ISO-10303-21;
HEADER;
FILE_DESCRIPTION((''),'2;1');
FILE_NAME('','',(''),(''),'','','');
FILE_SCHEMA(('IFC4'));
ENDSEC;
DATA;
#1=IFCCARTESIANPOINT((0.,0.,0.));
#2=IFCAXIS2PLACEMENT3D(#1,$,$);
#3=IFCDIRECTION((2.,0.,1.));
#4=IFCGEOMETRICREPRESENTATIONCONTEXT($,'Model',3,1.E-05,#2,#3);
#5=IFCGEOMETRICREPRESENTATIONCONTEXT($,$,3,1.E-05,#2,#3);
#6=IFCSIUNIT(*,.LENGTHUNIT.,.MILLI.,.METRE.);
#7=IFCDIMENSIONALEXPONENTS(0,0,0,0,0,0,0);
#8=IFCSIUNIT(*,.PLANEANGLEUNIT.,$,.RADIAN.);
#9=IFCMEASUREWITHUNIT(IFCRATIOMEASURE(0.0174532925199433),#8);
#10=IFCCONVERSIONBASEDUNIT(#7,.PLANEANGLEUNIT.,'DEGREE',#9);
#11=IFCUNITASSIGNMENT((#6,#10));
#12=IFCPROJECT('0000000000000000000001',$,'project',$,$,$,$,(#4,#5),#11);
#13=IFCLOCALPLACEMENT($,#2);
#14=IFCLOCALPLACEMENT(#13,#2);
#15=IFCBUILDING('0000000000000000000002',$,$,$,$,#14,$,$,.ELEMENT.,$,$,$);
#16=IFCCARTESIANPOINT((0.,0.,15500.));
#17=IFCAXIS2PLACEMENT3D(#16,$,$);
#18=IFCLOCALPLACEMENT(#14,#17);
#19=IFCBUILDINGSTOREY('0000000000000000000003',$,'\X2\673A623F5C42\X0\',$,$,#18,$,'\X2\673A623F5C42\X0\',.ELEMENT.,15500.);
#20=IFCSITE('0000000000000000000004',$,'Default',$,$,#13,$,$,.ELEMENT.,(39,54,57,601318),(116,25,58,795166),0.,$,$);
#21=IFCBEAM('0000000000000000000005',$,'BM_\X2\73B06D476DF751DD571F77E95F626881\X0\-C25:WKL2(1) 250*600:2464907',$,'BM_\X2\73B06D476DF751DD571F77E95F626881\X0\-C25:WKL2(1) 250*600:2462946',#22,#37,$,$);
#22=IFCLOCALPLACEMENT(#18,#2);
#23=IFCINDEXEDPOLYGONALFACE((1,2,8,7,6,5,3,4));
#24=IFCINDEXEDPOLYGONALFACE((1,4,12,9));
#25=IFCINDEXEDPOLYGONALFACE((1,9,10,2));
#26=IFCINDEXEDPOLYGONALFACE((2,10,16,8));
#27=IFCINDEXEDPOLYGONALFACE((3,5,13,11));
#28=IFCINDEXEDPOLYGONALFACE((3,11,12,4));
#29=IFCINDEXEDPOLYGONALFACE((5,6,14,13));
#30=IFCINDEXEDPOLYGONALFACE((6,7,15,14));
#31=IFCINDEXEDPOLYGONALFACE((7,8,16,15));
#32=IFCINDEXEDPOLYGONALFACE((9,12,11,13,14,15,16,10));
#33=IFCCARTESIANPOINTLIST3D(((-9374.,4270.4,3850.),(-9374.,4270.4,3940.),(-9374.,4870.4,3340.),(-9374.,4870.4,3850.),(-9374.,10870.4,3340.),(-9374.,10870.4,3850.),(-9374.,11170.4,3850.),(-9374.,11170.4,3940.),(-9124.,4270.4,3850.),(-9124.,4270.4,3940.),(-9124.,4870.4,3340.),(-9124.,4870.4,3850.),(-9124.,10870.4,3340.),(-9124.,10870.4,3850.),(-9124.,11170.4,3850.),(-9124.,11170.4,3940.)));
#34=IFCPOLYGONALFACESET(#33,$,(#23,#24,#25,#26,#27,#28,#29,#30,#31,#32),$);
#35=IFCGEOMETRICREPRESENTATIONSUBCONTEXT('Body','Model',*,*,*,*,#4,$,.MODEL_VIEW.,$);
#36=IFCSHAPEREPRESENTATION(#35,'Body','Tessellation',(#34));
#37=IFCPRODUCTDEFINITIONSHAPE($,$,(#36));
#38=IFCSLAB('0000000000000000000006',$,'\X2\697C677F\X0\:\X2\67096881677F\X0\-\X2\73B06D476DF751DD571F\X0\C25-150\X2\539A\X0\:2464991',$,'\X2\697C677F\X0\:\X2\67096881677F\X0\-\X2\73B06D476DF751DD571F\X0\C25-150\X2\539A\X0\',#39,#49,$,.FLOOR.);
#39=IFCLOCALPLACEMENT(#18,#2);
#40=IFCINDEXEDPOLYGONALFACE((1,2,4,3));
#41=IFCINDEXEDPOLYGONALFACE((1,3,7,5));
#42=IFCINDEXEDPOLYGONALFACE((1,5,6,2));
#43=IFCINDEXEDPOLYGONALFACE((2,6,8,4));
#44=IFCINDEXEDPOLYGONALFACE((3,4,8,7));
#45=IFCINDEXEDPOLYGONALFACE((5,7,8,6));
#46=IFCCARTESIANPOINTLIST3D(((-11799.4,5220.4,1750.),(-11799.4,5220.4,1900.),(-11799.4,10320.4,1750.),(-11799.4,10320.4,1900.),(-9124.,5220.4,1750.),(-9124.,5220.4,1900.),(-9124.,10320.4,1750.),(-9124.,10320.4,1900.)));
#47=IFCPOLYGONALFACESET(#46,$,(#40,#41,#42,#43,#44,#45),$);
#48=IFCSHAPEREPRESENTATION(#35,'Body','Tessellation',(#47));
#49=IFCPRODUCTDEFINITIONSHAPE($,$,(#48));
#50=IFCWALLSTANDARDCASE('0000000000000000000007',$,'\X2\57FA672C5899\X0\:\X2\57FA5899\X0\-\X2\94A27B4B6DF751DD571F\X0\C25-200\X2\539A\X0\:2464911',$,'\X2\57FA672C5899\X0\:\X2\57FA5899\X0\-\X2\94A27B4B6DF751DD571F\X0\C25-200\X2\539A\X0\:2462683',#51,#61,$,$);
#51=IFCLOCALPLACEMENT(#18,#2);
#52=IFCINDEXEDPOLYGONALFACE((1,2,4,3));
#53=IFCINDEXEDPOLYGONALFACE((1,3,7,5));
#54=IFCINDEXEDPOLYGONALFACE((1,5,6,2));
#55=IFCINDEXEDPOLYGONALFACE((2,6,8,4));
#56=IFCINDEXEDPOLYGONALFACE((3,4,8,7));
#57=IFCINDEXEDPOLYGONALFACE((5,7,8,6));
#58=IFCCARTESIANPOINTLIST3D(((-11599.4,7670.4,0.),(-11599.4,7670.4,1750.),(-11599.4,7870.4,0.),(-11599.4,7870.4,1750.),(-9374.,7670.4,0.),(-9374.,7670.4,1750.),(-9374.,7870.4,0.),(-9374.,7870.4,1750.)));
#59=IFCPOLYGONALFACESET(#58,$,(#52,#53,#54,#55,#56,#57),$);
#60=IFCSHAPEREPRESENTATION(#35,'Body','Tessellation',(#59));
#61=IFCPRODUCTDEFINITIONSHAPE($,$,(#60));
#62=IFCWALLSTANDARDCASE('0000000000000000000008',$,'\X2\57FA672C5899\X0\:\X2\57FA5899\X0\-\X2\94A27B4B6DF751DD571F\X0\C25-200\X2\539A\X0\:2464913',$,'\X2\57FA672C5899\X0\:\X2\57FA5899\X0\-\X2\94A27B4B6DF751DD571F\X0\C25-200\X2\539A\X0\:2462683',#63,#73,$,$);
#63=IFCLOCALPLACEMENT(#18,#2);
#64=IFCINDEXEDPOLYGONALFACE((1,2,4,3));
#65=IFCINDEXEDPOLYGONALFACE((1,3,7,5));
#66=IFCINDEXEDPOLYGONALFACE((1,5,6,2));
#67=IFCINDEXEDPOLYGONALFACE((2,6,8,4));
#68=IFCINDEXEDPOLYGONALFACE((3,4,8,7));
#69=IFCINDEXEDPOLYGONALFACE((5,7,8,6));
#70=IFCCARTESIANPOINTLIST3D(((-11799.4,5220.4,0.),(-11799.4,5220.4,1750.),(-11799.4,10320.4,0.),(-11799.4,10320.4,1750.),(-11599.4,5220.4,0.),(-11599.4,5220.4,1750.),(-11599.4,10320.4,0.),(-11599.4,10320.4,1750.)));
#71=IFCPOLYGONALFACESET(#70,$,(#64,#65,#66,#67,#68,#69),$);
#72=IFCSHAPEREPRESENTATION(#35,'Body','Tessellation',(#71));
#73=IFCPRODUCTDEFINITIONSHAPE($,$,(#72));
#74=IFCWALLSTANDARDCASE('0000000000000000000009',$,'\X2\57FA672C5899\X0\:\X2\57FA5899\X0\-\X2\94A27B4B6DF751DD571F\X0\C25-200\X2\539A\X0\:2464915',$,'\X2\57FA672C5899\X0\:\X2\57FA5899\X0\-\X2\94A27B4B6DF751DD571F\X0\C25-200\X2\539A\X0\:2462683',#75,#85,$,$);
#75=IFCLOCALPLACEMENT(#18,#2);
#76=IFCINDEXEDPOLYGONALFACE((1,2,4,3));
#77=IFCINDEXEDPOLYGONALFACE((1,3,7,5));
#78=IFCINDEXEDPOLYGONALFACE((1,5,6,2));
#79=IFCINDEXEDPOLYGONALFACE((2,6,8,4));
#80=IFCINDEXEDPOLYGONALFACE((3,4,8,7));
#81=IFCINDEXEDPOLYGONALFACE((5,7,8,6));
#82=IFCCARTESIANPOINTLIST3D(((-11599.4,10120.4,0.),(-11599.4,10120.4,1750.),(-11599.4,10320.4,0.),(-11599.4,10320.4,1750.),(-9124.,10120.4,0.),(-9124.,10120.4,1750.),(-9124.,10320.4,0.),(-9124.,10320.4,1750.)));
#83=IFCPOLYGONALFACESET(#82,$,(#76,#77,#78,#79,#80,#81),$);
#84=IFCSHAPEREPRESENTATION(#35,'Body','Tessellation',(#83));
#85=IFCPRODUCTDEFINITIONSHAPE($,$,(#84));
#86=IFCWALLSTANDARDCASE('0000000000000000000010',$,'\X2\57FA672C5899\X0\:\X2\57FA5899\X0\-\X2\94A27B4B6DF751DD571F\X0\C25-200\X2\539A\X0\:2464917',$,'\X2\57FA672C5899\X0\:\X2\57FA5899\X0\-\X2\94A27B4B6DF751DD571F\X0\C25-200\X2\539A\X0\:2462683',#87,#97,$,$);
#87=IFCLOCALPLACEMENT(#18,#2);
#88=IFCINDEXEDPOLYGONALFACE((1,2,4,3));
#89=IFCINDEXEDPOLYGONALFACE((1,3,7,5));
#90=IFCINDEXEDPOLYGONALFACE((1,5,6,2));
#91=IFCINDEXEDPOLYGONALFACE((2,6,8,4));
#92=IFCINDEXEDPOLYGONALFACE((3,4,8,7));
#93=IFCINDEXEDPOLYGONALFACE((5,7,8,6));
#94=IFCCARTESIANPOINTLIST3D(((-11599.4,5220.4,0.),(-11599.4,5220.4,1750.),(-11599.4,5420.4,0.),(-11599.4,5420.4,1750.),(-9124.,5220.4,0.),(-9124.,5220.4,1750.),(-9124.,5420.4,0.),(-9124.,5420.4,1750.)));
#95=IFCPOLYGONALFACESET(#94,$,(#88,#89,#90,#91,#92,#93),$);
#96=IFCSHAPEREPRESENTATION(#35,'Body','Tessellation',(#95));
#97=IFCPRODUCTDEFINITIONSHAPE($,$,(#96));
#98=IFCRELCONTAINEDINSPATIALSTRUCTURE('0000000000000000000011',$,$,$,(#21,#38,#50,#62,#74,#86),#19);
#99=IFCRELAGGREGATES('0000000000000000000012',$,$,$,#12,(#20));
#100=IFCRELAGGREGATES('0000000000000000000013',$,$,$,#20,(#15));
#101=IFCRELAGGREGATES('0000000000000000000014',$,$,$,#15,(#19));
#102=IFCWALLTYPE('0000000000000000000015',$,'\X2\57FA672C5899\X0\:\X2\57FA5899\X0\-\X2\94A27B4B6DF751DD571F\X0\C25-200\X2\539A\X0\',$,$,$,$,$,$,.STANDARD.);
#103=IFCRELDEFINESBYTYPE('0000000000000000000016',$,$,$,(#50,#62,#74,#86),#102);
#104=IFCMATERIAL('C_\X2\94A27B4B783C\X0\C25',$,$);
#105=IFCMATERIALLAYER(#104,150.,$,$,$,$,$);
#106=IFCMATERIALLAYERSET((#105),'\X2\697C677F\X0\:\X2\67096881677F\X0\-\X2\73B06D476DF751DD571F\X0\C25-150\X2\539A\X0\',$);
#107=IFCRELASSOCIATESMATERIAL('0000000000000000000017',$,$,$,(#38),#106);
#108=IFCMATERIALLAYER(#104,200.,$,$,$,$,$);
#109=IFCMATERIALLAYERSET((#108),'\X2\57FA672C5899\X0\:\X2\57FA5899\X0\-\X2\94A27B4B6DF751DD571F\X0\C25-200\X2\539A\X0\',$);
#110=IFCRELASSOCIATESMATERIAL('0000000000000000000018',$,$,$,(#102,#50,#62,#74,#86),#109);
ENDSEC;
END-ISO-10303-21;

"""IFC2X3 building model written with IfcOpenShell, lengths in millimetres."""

from ifc_helpers import new_model, entity, si_unit, converted_unit, direction, frame, frame_2d, origin, place, context, subcontext, project, spatial, polyline, rectangle, extrude, clip, bounded_halfspace, material, layer, layer_set, layer_usage, type_object, element, save


model = new_model("IFC2X3")

# Units and contexts
model_context = context("Model", 3, precision=1e-05, world=origin(), true_north=direction((2.0, 0.0, 1.0)))
context_of_model = context(None, 3, precision=1e-05, world=origin(), true_north=direction((2.0, 0.0, 1.0)))
body_context = subcontext(model_context, "Body", "Model", "MODEL_VIEW")
ifc_project = project(units=[si_unit("LENGTHUNIT", "METRE", prefix="MILLI"), converted_unit("PLANEANGLEUNIT", "DEGREE", entity("IfcRatioMeasure", 0.0174532925199433), si_unit("PLANEANGLEUNIT", "RADIAN"), dimensions=[0, 0, 0, 0, 0, 0, 0])], contexts=[model_context, context_of_model])

# Site, building, storey
site_placement = place(None, origin())
site = spatial("IfcSite", under=ifc_project, at=site_placement, Name="Default", CompositionType="ELEMENT", RefLatitude=(39, 54, 57, 601318), RefLongitude=(116, 25, 58, 795166), RefElevation=0.0)
building_placement = place(site_placement, origin())
building = spatial("IfcBuilding", under=site, at=building_placement, CompositionType="ELEMENT")
storey_placement = place(building_placement, frame((0.0, 0.0, 15500.0)))
storey = spatial("IfcBuildingStorey", under=building, at=storey_placement, Name="机房层", LongName="机房层", CompositionType="ELEMENT", Elevation=15500.0)

# Shared definitions
ifc_material = material(Name="C_钢筋砼C25")

# Beam
beam_1_placement = place(storey_placement, frame((-9249.0, 11170.4, 3940.0), z_axis=(0.0, 0.0, 1.0), x_axis=(0.0, -1.0, 0.0)))
element("IfcBeam", 1, at=beam_1_placement, inside=storey, Name="BM_现浇混凝土矩形梁-C25:WKL2(1) 250*600:2464907", ObjectType="BM_现浇混凝土矩形梁-C25:WKL2(1) 250*600:2462946", context=body_context, shape_type="Clipping", body=[
    clip(clip(extrude(rectangle(XDim=600.0, YDim=250.0, at=frame_2d((0.0, 0.0), x_axis=(0.0, 1.0))), frame((0.0, 0.0, -300.0), z_axis=(1.0, 0.0, 0.0), x_axis=(0.0, 1.0, 0.0)), (0.0, 0.0, 1.0), 6900.0), bounded_halfspace(frame((6300.0, 125.0, -90.0), z_axis=(1.0, 0.0, 0.0), x_axis=(0.0, 0.0, -1.0)), False, frame((0.0, 0.0, -300.0), z_axis=(1.0, 0.0, 0.0), x_axis=(0.0, 1.0, 0.0)), polyline([(125.0, -300.0), (125.0, 159.4), (125.0, 210.0), (-125.0, 210.0), (-125.0, 189.2), (-125.0, -300.0), (125.0, -300.0)]))), bounded_halfspace(frame((300.0, -300.0, -90.0), z_axis=(-1.0, 0.0, 0.0), x_axis=(0.0, 0.0, 1.0)), False, frame((0.0, 0.0, -300.0), z_axis=(1.0, 0.0, 0.0), x_axis=(0.0, 1.0, 0.0)), polyline([(-125.0, 210.0), (125.0, 210.0), (125.0, -300.0), (-125.0, -300.0), (-125.0, 210.0)]))),
])

# Slab
ifc_layer_1 = layer(ifc_material, 150.0)
ifc_layer_set_1 = layer_set([ifc_layer_1], Name="楼板:有梁板-现浇混凝土C25-150厚")
ifc_layer_usage_1 = layer_usage(ifc_layer_set_1, "AXIS3", "POSITIVE", 0.0)
slab_1_placement = place(storey_placement, origin())
element("IfcSlab", 2, at=slab_1_placement, inside=storey, material=ifc_layer_usage_1, Name="楼板:有梁板-现浇混凝土C25-150厚:2464991", ObjectType="楼板:有梁板-现浇混凝土C25-150厚", PredefinedType="FLOOR", context=body_context, shape_type="SweptSolid", body=[
    extrude(rectangle(XDim=5100.0, YDim=2675.4, at=frame_2d((0.0, 0.0), x_axis=(1.0, 0.0))), frame((-10461.7, 7770.4, 1900.0), z_axis=(0.0, 0.0, -1.0), x_axis=(0.0, 1.0, 0.0)), (0.0, 0.0, 1.0), 150.0),
])

# Walls
ifc_layer_2 = layer(ifc_material, 200.0)
ifc_layer_set_2 = layer_set([ifc_layer_2], Name="基本墙:基墙-钢筋混凝土C25-200厚")
ifc_layer_usage_2 = layer_usage(ifc_layer_set_2, "AXIS2", "NEGATIVE", 100.0)
wall_type_1 = type_object("IfcWallType", Name="基本墙:基墙-钢筋混凝土C25-200厚", PredefinedType="STANDARD", material=ifc_layer_set_2)
wall_1_placement = place(storey_placement, frame((-9374.0, 7770.4, 0.0), z_axis=(0.0, 0.0, 1.0), x_axis=(-1.0, 0.0, 0.0)))
element("IfcWallStandardCase", 3, at=wall_1_placement, inside=storey, type_object=wall_type_1, material=ifc_layer_usage_2, Name="基本墙:基墙-钢筋混凝土C25-200厚:2464911", ObjectType="基本墙:基墙-钢筋混凝土C25-200厚:2462683", context=body_context, shape_type="Clipping", body=[
    clip(extrude(rectangle(XDim=2225.4, YDim=200.0, at=frame_2d((1112.7, 0.0), x_axis=(-1.0, 0.0))), origin(), (0.0, 0.0, 1.0), 1900.0), bounded_halfspace(frame((0.0, -100.0, 1750.0), z_axis=(0.0, 0.0, -1.0), x_axis=(0.0, 1.0, 0.0)), True, frame((0.0, -100.0, 1750.0), z_axis=(0.0, 0.0, -1.0), x_axis=(0.0, 1.0, 0.0)), polyline([(0.0, 0.0), (200.0, 0.0), (200.0, 2225.4), (0.0, 2225.4), (0.0, 0.0)]))),
])
ifc_layer_usage_3 = layer_usage(ifc_layer_set_2, "AXIS2", "NEGATIVE", 100.0)
wall_2_placement = place(storey_placement, frame((-11699.4, 10320.4, 0.0), z_axis=(0.0, 0.0, 1.0), x_axis=(0.0, -1.0, 0.0)))
element("IfcWallStandardCase", 4, at=wall_2_placement, inside=storey, type_object=wall_type_1, material=ifc_layer_usage_3, Name="基本墙:基墙-钢筋混凝土C25-200厚:2464913", ObjectType="基本墙:基墙-钢筋混凝土C25-200厚:2462683", context=body_context, shape_type="Clipping", body=[
    clip(extrude(rectangle(XDim=5100.0, YDim=200.0, at=frame_2d((2550.0, 0.0), x_axis=(-1.0, 0.0))), origin(), (0.0, 0.0, 1.0), 1900.0), bounded_halfspace(frame((0.0, -100.0, 1750.0), z_axis=(0.0, 0.0, -1.0), x_axis=(1.0, 0.0, 0.0)), True, frame((0.0, -100.0, 1750.0), z_axis=(0.0, 0.0, -1.0), x_axis=(1.0, 0.0, 0.0)), polyline([(0.0, 0.0), (0.0, -200.0), (200.0, -200.0), (2450.0, -200.0), (2650.0, -200.0), (4900.0, -200.0), (5100.0, -200.0), (5100.0, 0.0), (0.0, 0.0)]))),
])
ifc_layer_usage_4 = layer_usage(ifc_layer_set_2, "AXIS2", "NEGATIVE", 100.0)
wall_3_placement = place(storey_placement, frame((-9124.0, 10220.4, 0.0), z_axis=(0.0, 0.0, 1.0), x_axis=(-1.0, 0.0, 0.0)))
element("IfcWallStandardCase", 5, at=wall_3_placement, inside=storey, type_object=wall_type_1, material=ifc_layer_usage_4, Name="基本墙:基墙-钢筋混凝土C25-200厚:2464915", ObjectType="基本墙:基墙-钢筋混凝土C25-200厚:2462683", context=body_context, shape_type="Clipping", body=[
    clip(extrude(rectangle(XDim=2475.4, YDim=200.0, at=frame_2d((1237.7, 0.0), x_axis=(-1.0, 0.0))), origin(), (0.0, 0.0, 1.0), 1900.0), bounded_halfspace(frame((0.0, -100.0, 1750.0), z_axis=(0.0, 0.0, -1.0), x_axis=(0.0, 1.0, 0.0)), True, frame((0.0, -100.0, 1750.0), z_axis=(0.0, 0.0, -1.0), x_axis=(0.0, 1.0, 0.0)), polyline([(0.0, 0.0), (200.0, 0.0), (200.0, 250.0), (200.0, 2475.4), (0.0, 2475.4), (0.0, 0.0)]))),
])
ifc_layer_usage_5 = layer_usage(ifc_layer_set_2, "AXIS2", "NEGATIVE", 100.0)
wall_4_placement = place(storey_placement, frame((-9124.0, 5320.4, 0.0), z_axis=(0.0, 0.0, 1.0), x_axis=(-1.0, 0.0, 0.0)))
element("IfcWallStandardCase", 6, at=wall_4_placement, inside=storey, type_object=wall_type_1, material=ifc_layer_usage_5, Name="基本墙:基墙-钢筋混凝土C25-200厚:2464917", ObjectType="基本墙:基墙-钢筋混凝土C25-200厚:2462683", context=body_context, shape_type="Clipping", body=[
    clip(extrude(rectangle(XDim=2475.4, YDim=200.0, at=frame_2d((1237.7, 0.0), x_axis=(-1.0, 0.0))), origin(), (0.0, 0.0, 1.0), 1900.0), bounded_halfspace(frame((0.0, -100.0, 1750.0), z_axis=(0.0, 0.0, -1.0), x_axis=(0.0, 1.0, 0.0)), True, frame((0.0, -100.0, 1750.0), z_axis=(0.0, 0.0, -1.0), x_axis=(0.0, 1.0, 0.0)), polyline([(0.0, 0.0), (200.0, 0.0), (200.0, 2475.4), (0.0, 2475.4), (0.0, 250.0), (0.0, 0.0)]))),
])

save(model, "model.ifc")
